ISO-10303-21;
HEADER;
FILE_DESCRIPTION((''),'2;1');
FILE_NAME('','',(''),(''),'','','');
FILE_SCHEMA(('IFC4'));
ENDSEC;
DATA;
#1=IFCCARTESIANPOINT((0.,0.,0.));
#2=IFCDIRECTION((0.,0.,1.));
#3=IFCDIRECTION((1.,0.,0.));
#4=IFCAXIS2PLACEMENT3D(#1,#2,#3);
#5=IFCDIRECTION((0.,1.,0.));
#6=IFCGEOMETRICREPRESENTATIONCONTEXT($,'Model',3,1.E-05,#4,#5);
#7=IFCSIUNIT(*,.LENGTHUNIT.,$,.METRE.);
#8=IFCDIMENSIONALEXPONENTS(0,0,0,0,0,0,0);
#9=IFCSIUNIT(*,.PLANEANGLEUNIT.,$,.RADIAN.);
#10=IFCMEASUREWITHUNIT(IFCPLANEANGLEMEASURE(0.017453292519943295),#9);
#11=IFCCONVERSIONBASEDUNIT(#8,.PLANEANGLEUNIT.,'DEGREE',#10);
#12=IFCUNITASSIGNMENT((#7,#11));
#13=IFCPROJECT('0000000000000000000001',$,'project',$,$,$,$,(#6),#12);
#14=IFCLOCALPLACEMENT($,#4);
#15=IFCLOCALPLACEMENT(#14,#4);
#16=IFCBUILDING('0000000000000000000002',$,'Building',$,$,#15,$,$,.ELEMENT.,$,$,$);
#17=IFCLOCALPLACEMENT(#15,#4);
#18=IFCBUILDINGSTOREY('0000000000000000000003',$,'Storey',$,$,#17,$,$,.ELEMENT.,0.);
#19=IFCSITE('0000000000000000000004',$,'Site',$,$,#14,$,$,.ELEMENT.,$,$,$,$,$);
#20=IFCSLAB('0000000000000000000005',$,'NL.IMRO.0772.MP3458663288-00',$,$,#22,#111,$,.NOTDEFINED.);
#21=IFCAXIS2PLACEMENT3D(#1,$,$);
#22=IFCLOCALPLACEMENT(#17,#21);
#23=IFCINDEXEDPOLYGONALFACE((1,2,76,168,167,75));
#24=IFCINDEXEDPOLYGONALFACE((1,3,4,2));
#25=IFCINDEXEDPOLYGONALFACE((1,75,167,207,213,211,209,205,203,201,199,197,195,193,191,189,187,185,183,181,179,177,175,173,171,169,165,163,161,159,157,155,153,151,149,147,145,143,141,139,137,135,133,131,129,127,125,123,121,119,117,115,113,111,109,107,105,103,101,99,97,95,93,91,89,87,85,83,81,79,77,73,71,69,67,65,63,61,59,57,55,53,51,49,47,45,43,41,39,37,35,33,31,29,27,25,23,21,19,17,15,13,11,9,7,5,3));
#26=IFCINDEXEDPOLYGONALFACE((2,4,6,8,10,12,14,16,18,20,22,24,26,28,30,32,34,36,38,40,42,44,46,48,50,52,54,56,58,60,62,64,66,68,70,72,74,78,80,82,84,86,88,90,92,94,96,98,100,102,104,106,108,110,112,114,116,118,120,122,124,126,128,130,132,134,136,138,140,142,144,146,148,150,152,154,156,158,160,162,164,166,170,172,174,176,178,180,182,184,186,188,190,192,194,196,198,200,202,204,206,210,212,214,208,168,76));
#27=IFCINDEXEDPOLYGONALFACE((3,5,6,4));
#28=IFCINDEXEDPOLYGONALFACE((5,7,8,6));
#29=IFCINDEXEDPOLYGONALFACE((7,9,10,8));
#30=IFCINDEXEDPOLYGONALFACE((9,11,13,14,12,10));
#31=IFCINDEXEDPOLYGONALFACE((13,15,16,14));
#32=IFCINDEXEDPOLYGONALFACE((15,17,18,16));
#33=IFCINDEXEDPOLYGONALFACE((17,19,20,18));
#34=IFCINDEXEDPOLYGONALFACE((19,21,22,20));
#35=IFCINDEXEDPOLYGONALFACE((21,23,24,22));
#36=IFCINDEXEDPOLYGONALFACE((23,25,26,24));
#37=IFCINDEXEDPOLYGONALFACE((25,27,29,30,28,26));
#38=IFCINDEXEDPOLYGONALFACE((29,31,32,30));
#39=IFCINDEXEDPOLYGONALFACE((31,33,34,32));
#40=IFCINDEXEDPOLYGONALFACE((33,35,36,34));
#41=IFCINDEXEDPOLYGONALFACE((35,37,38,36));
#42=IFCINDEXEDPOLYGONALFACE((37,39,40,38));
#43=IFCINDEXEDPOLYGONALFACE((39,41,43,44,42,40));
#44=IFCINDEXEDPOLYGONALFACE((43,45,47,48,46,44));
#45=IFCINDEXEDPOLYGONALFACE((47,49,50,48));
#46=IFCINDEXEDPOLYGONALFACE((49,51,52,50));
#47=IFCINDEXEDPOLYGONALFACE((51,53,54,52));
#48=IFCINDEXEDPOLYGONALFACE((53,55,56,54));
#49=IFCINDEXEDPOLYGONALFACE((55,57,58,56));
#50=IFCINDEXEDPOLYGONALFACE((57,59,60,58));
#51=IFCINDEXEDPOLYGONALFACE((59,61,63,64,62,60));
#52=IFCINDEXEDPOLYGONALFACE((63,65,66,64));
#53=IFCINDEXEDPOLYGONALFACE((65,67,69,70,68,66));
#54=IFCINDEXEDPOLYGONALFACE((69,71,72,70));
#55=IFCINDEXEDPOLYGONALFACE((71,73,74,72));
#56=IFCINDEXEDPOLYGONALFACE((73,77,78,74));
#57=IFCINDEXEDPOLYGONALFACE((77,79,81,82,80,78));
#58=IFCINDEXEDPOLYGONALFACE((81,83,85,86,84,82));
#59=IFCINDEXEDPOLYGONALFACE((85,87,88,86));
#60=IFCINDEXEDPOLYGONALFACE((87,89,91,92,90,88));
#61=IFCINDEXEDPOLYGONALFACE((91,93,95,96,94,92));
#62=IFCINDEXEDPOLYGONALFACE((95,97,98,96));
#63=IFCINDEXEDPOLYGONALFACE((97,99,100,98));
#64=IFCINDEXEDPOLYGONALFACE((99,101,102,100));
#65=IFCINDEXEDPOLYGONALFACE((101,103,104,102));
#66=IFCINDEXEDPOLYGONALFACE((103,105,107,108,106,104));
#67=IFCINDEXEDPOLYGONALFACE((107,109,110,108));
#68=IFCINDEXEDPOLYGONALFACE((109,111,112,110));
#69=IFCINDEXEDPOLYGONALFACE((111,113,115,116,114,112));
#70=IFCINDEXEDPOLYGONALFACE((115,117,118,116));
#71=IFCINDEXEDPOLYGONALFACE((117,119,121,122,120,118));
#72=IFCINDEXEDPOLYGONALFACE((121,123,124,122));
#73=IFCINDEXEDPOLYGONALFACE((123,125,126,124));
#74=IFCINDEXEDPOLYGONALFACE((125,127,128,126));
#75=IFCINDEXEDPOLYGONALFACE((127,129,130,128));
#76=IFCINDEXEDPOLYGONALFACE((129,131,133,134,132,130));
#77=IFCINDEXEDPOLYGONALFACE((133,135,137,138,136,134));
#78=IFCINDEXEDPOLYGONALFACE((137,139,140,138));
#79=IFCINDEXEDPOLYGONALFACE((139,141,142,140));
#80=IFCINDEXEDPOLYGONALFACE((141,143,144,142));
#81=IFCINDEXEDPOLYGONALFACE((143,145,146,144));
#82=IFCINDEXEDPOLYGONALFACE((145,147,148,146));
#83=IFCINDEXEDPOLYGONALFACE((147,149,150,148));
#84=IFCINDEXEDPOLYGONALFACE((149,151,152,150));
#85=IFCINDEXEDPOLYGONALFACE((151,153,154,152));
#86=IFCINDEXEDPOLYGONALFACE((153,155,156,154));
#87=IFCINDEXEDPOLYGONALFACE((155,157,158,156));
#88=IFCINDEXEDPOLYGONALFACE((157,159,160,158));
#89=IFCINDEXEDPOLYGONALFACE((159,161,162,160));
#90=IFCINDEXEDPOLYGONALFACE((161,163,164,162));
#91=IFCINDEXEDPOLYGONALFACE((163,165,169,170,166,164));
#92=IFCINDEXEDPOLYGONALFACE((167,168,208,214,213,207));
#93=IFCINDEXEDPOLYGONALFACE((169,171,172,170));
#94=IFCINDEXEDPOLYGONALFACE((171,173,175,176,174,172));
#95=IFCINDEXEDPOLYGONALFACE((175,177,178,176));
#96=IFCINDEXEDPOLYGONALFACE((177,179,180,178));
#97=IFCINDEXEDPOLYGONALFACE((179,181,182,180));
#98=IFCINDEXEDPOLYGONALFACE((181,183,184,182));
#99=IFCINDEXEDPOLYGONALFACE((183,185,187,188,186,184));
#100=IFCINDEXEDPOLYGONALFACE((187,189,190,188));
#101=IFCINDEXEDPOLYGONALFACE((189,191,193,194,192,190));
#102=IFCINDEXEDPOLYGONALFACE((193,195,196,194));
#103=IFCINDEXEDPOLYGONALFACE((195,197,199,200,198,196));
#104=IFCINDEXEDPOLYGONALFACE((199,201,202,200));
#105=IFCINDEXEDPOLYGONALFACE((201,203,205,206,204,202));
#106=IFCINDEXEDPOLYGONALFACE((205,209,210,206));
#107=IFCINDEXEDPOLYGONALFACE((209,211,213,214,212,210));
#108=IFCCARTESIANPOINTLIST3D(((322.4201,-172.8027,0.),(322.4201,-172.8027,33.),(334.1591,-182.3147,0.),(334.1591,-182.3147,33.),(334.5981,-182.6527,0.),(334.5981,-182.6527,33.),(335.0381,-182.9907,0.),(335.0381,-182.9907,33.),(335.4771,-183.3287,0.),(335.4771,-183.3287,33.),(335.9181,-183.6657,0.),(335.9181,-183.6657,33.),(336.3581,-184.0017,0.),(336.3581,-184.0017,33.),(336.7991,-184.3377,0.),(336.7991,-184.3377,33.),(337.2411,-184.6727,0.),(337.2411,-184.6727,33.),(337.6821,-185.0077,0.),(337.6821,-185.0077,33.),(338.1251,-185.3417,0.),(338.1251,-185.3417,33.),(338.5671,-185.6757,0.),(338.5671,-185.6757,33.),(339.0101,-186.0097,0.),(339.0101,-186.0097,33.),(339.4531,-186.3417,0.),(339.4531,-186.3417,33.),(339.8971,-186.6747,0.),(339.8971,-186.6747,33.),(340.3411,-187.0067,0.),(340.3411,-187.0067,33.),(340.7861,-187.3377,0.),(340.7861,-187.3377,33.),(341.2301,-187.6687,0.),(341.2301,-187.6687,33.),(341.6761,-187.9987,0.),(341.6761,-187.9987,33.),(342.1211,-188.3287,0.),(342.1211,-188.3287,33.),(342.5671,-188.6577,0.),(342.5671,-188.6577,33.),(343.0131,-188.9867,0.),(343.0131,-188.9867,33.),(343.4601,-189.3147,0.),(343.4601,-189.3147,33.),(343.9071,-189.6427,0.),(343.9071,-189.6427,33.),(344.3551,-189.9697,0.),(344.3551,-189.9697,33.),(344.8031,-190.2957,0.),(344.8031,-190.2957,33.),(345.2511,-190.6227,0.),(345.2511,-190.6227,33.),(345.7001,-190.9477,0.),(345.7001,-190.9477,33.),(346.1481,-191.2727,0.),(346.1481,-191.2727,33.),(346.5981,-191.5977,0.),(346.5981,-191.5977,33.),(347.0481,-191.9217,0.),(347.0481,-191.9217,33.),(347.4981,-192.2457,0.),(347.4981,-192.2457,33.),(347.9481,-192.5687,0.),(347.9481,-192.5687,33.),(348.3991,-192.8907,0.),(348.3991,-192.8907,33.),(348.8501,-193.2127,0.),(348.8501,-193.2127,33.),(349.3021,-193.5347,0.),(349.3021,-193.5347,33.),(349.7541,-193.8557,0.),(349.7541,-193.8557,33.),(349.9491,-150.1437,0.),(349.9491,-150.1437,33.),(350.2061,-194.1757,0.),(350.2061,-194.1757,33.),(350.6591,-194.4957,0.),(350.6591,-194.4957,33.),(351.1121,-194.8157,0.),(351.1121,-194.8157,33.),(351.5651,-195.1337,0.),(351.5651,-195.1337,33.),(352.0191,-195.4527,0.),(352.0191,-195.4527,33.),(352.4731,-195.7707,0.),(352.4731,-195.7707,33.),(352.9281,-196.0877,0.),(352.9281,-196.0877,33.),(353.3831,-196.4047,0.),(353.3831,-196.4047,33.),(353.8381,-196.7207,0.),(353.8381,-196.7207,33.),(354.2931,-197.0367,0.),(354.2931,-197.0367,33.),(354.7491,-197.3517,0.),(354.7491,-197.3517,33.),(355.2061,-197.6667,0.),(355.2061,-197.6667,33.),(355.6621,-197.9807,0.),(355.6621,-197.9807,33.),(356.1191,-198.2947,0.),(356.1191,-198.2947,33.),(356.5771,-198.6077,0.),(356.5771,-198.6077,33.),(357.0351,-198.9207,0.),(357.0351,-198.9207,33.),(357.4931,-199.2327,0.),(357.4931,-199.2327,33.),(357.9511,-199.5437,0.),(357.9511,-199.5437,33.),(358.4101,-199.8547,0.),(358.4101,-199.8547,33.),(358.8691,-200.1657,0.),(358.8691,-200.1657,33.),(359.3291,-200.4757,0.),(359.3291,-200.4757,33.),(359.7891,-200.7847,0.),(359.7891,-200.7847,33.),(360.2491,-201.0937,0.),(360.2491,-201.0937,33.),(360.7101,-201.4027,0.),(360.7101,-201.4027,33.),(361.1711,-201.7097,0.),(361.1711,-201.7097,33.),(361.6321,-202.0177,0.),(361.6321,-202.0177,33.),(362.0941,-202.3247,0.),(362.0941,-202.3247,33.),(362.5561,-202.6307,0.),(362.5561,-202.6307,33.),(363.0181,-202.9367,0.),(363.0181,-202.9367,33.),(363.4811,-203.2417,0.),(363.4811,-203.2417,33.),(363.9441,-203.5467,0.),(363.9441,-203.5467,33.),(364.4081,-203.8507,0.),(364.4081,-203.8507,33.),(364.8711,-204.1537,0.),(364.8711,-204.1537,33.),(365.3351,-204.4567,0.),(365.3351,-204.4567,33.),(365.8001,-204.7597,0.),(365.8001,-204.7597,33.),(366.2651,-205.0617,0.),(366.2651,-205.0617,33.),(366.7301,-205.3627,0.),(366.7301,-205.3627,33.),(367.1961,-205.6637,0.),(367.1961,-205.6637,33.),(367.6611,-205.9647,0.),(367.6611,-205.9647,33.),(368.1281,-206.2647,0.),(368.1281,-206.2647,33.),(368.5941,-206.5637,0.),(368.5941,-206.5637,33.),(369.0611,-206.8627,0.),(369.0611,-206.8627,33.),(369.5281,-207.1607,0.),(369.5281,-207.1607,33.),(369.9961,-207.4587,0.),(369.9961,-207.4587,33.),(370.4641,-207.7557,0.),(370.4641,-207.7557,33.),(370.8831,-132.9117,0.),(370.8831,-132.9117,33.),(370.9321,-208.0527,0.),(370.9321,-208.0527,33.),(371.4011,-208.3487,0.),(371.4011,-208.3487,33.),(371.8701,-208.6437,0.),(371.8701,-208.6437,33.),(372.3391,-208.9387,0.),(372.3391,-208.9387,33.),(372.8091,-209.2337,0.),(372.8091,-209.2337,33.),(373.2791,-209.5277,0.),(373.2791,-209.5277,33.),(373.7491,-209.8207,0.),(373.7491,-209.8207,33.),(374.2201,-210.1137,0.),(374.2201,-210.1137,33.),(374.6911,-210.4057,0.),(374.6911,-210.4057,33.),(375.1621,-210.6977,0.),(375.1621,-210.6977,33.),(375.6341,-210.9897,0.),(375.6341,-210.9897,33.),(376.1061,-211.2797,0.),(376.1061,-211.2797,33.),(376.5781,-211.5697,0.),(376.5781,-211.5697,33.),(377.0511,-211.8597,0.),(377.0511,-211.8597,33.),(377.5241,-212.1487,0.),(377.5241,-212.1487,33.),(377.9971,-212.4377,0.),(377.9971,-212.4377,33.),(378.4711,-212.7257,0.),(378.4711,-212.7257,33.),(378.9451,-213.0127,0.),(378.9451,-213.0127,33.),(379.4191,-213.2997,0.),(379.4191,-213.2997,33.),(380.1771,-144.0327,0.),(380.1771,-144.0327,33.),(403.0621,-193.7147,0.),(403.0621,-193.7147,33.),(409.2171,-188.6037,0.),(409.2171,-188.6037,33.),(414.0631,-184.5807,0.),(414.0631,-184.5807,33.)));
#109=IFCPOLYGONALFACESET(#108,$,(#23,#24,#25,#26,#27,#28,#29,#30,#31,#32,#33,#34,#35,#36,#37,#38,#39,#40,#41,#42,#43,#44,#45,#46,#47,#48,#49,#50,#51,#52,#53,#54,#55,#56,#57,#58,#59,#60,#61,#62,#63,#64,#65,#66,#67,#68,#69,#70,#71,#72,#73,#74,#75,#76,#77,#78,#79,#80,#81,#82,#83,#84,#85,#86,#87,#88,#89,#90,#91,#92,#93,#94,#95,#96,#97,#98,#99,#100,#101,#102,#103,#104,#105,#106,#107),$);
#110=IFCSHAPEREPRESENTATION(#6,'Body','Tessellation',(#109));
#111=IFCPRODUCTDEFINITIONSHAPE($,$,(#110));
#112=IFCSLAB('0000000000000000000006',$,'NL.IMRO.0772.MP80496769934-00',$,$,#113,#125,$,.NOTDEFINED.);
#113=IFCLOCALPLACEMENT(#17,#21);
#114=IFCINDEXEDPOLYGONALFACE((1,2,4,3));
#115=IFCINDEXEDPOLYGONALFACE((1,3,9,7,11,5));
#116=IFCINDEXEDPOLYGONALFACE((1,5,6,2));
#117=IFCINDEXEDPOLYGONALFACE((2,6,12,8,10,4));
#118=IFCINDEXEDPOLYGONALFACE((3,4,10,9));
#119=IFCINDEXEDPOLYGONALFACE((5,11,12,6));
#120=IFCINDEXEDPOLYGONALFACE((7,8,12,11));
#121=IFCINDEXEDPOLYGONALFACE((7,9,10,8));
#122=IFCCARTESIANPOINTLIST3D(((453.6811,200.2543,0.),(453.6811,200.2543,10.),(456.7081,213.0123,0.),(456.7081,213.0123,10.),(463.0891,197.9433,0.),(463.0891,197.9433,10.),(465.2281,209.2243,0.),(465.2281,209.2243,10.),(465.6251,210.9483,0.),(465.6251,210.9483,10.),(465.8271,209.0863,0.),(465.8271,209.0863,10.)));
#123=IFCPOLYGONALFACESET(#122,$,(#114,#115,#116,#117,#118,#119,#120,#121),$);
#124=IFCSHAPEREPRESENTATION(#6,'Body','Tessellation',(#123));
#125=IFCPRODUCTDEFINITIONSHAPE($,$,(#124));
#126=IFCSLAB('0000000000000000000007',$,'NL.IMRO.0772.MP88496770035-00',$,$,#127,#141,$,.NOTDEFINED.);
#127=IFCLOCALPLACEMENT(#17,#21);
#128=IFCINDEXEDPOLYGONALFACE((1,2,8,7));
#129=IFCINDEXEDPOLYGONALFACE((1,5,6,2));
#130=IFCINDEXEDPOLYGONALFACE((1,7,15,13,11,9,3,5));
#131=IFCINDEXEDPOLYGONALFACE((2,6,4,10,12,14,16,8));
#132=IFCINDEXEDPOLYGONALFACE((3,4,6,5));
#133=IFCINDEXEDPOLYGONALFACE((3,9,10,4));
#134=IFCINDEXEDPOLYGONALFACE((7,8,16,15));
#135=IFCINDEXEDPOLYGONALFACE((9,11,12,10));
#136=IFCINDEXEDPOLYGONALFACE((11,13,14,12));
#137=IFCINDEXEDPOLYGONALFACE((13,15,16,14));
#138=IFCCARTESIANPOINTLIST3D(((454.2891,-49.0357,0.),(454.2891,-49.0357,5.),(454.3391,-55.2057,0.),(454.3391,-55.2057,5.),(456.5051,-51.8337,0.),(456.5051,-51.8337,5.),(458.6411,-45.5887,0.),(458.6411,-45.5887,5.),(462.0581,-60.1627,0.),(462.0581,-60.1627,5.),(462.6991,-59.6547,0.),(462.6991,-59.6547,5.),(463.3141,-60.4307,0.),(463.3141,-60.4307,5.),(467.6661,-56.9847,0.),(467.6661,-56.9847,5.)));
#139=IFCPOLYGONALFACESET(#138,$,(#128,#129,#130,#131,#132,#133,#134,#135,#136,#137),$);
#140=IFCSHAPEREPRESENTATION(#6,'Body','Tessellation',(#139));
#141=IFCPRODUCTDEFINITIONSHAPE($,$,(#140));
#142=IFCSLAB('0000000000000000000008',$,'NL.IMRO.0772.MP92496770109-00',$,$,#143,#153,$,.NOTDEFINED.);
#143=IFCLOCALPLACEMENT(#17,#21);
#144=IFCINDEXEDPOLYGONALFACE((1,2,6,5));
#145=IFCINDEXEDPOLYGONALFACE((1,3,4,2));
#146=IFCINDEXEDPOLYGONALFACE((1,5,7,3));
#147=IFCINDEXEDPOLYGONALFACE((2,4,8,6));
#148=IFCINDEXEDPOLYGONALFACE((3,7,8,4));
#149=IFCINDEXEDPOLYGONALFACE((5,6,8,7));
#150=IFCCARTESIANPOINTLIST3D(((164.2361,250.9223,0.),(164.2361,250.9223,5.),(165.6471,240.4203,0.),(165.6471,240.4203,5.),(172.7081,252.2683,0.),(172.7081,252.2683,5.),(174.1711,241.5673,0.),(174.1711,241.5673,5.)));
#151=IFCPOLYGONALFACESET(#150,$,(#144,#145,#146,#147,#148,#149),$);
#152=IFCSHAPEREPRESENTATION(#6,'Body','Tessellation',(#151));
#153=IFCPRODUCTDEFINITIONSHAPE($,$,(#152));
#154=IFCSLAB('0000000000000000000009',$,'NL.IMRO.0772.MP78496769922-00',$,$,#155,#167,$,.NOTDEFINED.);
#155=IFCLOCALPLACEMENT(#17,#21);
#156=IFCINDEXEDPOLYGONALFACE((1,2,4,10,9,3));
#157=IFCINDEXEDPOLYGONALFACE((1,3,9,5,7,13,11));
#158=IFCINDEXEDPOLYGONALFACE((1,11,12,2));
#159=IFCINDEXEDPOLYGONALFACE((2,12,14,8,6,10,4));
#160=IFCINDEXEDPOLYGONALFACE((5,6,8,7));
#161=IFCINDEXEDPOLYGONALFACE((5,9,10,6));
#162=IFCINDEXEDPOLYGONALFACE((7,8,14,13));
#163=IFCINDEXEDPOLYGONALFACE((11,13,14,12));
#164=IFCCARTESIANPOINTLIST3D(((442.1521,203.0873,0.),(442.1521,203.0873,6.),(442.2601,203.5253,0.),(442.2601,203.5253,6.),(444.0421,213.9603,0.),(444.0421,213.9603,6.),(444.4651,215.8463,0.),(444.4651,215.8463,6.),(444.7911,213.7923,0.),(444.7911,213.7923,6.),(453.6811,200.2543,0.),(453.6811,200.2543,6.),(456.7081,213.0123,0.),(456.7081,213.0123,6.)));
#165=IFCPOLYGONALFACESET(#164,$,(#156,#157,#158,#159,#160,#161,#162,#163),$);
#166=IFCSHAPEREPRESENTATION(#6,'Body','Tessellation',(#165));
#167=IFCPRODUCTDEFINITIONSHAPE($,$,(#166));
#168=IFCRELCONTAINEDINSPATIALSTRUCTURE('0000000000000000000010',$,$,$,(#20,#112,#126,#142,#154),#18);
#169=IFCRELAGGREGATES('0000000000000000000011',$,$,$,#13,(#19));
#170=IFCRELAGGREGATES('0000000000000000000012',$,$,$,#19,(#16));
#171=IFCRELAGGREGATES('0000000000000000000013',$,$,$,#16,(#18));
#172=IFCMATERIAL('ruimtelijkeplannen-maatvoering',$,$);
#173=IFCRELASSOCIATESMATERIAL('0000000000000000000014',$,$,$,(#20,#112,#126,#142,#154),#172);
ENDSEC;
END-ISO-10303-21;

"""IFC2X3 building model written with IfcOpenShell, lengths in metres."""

from ifc_helpers import new_model, entity, si_unit, converted_unit, direction, origin_with_axes, place, context, project, spatial, polyline, outline, extrude, material, element, save


model = new_model("IFC2X3")

# Units and contexts
model_context = context("Model", 3, precision=1e-05, world=origin_with_axes(), true_north=direction((0.0, 1.0, 0.0)))
ifc_project = project(units=[si_unit("LENGTHUNIT", "METRE"), converted_unit("PLANEANGLEUNIT", "DEGREE", entity("IfcPlaneAngleMeasure", 0.017453292519943295), si_unit("PLANEANGLEUNIT", "RADIAN"), dimensions=[0, 0, 0, 0, 0, 0, 0])], contexts=[model_context])

# Site, building, storey
site_placement = place(None, origin_with_axes())
site = spatial("IfcSite", under=ifc_project, at=site_placement, Name="Site", CompositionType="ELEMENT")
building_placement = place(site_placement, origin_with_axes())
building = spatial("IfcBuilding", under=site, at=building_placement, Name="Building", CompositionType="ELEMENT")
storey_placement = place(building_placement, origin_with_axes())
storey = spatial("IfcBuildingStorey", under=building, at=storey_placement, Name="Storey", CompositionType="ELEMENT", Elevation=0.0)

# Slabs
ifc_material = material(Name="ruimtelijkeplannen-maatvoering")
slab_1_placement = place(storey_placement, origin_with_axes())
element("IfcSlab", 1, at=slab_1_placement, inside=storey, material=ifc_material, Name="NL.IMRO.0772.MP3458663288-00", PredefinedType="NOTDEFINED", context=model_context, shape_type="SweptSolid", body=[
    extrude(outline(polyline([(322.4201, -172.8027), (349.9491, -150.1437), (370.8831, -132.9117), (380.1771, -144.0327), (414.0631, -184.5807), (409.2171, -188.6037), (403.0621, -193.7147), (379.4191, -213.2997), (378.9451, -213.0127), (378.4711, -212.7257), (377.9971, -212.4377), (377.5241, -212.1487), (377.0511, -211.8597), (376.5781, -211.5697), (376.1061, -211.2797), (375.6341, -210.9897), (375.1621, -210.6977), (374.6911, -210.4057), (374.2201, -210.1137), (373.7491, -209.8207), (373.2791, -209.5277), (372.8091, -209.2337), (372.3391, -208.9387), (371.8701, -208.6437), (371.4011, -208.3487), (370.9321, -208.0527), (370.4641, -207.7557), (369.9961, -207.4587), (369.5281, -207.1607), (369.0611, -206.8627), (368.5941, -206.5637), (368.1281, -206.2647), (367.6611, -205.9647), (367.1961, -205.6637), (366.7301, -205.3627), (366.2651, -205.0617), (365.8001, -204.7597), (365.3351, -204.4567), (364.8711, -204.1537), (364.4081, -203.8507), (363.9441, -203.5467), (363.4811, -203.2417), (363.0181, -202.9367), (362.5561, -202.6307), (362.0941, -202.3247), (361.6321, -202.0177), (361.1711, -201.7097), (360.7101, -201.4027), (360.2491, -201.0937), (359.7891, -200.7847), (359.3291, -200.4757), (358.8691, -200.1657), (358.4101, -199.8547), (357.9511, -199.5437), (357.4931, -199.2327), (357.0351, -198.9207), (356.5771, -198.6077), (356.1191, -198.2947), (355.6621, -197.9807), (355.2061, -197.6667), (354.7491, -197.3517), (354.2931, -197.0367), (353.8381, -196.7207), (353.3831, -196.4047), (352.9281, -196.0877), (352.4731, -195.7707), (352.0191, -195.4527), (351.5651, -195.1337), (351.1121, -194.8157), (350.6591, -194.4957), (350.2061, -194.1757), (349.7541, -193.8557), (349.3021, -193.5347), (348.8501, -193.2127), (348.3991, -192.8907), (347.9481, -192.5687), (347.4981, -192.2457), (347.0481, -191.9217), (346.5981, -191.5977), (346.1481, -191.2727), (345.7001, -190.9477), (345.2511, -190.6227), (344.8031, -190.2957), (344.3551, -189.9697), (343.9071, -189.6427), (343.4601, -189.3147), (343.0131, -188.9867), (342.5671, -188.6577), (342.1211, -188.3287), (341.6761, -187.9987), (341.2301, -187.6687), (340.7861, -187.3377), (340.3411, -187.0067), (339.8971, -186.6747), (339.4531, -186.3417), (339.0101, -186.0097), (338.5671, -185.6757), (338.1251, -185.3417), (337.6821, -185.0077), (337.2411, -184.6727), (336.7991, -184.3377), (336.3581, -184.0017), (335.9181, -183.6657), (335.4771, -183.3287), (335.0381, -182.9907), (334.5981, -182.6527), (334.1591, -182.3147), (322.4201, -172.8027)])), origin_with_axes(), (0.0, 0.0, 1.0), 33.0),
])
slab_2_placement = place(storey_placement, origin_with_axes())
element("IfcSlab", 2, at=slab_2_placement, inside=storey, material=ifc_material, Name="NL.IMRO.0772.MP80496769934-00", PredefinedType="NOTDEFINED", context=model_context, shape_type="SweptSolid", body=[
    extrude(outline(polyline([(456.7081, 213.0123), (465.6251, 210.9483), (465.2281, 209.2243), (465.8271, 209.0863), (463.0891, 197.9433), (453.6811, 200.2543), (456.7081, 213.0123)])), origin_with_axes(), (0.0, 0.0, 1.0), 10.0),
])
slab_3_placement = place(storey_placement, origin_with_axes())
element("IfcSlab", 3, at=slab_3_placement, inside=storey, material=ifc_material, Name="NL.IMRO.0772.MP88496770035-00", PredefinedType="NOTDEFINED", context=model_context, shape_type="SweptSolid", body=[
    extrude(outline(polyline([(467.6661, -56.9847), (463.3141, -60.4307), (462.6991, -59.6547), (462.0581, -60.1627), (454.3391, -55.2057), (456.5051, -51.8337), (454.2891, -49.0357), (458.6411, -45.5887), (467.6661, -56.9847)])), origin_with_axes(), (0.0, 0.0, 1.0), 5.0),
])
slab_4_placement = place(storey_placement, origin_with_axes())
element("IfcSlab", 4, at=slab_4_placement, inside=storey, material=ifc_material, Name="NL.IMRO.0772.MP92496770109-00", PredefinedType="NOTDEFINED", context=model_context, shape_type="SweptSolid", body=[
    extrude(outline(polyline([(165.6471, 240.4203), (164.2361, 250.9223), (172.7081, 252.2683), (174.1711, 241.5673), (165.6471, 240.4203)])), origin_with_axes(), (0.0, 0.0, 1.0), 5.0),
])
slab_5_placement = place(storey_placement, origin_with_axes())
element("IfcSlab", 5, at=slab_5_placement, inside=storey, material=ifc_material, Name="NL.IMRO.0772.MP78496769922-00", PredefinedType="NOTDEFINED", context=model_context, shape_type="SweptSolid", body=[
    extrude(outline(polyline([(453.6811, 200.2543), (442.1521, 203.0873), (442.2601, 203.5253), (444.7911, 213.7923), (444.0421, 213.9603), (444.4651, 215.8463), (456.7081, 213.0123), (453.6811, 200.2543)])), origin_with_axes(), (0.0, 0.0, 1.0), 6.0),
])

save(model, "model.ifc")
